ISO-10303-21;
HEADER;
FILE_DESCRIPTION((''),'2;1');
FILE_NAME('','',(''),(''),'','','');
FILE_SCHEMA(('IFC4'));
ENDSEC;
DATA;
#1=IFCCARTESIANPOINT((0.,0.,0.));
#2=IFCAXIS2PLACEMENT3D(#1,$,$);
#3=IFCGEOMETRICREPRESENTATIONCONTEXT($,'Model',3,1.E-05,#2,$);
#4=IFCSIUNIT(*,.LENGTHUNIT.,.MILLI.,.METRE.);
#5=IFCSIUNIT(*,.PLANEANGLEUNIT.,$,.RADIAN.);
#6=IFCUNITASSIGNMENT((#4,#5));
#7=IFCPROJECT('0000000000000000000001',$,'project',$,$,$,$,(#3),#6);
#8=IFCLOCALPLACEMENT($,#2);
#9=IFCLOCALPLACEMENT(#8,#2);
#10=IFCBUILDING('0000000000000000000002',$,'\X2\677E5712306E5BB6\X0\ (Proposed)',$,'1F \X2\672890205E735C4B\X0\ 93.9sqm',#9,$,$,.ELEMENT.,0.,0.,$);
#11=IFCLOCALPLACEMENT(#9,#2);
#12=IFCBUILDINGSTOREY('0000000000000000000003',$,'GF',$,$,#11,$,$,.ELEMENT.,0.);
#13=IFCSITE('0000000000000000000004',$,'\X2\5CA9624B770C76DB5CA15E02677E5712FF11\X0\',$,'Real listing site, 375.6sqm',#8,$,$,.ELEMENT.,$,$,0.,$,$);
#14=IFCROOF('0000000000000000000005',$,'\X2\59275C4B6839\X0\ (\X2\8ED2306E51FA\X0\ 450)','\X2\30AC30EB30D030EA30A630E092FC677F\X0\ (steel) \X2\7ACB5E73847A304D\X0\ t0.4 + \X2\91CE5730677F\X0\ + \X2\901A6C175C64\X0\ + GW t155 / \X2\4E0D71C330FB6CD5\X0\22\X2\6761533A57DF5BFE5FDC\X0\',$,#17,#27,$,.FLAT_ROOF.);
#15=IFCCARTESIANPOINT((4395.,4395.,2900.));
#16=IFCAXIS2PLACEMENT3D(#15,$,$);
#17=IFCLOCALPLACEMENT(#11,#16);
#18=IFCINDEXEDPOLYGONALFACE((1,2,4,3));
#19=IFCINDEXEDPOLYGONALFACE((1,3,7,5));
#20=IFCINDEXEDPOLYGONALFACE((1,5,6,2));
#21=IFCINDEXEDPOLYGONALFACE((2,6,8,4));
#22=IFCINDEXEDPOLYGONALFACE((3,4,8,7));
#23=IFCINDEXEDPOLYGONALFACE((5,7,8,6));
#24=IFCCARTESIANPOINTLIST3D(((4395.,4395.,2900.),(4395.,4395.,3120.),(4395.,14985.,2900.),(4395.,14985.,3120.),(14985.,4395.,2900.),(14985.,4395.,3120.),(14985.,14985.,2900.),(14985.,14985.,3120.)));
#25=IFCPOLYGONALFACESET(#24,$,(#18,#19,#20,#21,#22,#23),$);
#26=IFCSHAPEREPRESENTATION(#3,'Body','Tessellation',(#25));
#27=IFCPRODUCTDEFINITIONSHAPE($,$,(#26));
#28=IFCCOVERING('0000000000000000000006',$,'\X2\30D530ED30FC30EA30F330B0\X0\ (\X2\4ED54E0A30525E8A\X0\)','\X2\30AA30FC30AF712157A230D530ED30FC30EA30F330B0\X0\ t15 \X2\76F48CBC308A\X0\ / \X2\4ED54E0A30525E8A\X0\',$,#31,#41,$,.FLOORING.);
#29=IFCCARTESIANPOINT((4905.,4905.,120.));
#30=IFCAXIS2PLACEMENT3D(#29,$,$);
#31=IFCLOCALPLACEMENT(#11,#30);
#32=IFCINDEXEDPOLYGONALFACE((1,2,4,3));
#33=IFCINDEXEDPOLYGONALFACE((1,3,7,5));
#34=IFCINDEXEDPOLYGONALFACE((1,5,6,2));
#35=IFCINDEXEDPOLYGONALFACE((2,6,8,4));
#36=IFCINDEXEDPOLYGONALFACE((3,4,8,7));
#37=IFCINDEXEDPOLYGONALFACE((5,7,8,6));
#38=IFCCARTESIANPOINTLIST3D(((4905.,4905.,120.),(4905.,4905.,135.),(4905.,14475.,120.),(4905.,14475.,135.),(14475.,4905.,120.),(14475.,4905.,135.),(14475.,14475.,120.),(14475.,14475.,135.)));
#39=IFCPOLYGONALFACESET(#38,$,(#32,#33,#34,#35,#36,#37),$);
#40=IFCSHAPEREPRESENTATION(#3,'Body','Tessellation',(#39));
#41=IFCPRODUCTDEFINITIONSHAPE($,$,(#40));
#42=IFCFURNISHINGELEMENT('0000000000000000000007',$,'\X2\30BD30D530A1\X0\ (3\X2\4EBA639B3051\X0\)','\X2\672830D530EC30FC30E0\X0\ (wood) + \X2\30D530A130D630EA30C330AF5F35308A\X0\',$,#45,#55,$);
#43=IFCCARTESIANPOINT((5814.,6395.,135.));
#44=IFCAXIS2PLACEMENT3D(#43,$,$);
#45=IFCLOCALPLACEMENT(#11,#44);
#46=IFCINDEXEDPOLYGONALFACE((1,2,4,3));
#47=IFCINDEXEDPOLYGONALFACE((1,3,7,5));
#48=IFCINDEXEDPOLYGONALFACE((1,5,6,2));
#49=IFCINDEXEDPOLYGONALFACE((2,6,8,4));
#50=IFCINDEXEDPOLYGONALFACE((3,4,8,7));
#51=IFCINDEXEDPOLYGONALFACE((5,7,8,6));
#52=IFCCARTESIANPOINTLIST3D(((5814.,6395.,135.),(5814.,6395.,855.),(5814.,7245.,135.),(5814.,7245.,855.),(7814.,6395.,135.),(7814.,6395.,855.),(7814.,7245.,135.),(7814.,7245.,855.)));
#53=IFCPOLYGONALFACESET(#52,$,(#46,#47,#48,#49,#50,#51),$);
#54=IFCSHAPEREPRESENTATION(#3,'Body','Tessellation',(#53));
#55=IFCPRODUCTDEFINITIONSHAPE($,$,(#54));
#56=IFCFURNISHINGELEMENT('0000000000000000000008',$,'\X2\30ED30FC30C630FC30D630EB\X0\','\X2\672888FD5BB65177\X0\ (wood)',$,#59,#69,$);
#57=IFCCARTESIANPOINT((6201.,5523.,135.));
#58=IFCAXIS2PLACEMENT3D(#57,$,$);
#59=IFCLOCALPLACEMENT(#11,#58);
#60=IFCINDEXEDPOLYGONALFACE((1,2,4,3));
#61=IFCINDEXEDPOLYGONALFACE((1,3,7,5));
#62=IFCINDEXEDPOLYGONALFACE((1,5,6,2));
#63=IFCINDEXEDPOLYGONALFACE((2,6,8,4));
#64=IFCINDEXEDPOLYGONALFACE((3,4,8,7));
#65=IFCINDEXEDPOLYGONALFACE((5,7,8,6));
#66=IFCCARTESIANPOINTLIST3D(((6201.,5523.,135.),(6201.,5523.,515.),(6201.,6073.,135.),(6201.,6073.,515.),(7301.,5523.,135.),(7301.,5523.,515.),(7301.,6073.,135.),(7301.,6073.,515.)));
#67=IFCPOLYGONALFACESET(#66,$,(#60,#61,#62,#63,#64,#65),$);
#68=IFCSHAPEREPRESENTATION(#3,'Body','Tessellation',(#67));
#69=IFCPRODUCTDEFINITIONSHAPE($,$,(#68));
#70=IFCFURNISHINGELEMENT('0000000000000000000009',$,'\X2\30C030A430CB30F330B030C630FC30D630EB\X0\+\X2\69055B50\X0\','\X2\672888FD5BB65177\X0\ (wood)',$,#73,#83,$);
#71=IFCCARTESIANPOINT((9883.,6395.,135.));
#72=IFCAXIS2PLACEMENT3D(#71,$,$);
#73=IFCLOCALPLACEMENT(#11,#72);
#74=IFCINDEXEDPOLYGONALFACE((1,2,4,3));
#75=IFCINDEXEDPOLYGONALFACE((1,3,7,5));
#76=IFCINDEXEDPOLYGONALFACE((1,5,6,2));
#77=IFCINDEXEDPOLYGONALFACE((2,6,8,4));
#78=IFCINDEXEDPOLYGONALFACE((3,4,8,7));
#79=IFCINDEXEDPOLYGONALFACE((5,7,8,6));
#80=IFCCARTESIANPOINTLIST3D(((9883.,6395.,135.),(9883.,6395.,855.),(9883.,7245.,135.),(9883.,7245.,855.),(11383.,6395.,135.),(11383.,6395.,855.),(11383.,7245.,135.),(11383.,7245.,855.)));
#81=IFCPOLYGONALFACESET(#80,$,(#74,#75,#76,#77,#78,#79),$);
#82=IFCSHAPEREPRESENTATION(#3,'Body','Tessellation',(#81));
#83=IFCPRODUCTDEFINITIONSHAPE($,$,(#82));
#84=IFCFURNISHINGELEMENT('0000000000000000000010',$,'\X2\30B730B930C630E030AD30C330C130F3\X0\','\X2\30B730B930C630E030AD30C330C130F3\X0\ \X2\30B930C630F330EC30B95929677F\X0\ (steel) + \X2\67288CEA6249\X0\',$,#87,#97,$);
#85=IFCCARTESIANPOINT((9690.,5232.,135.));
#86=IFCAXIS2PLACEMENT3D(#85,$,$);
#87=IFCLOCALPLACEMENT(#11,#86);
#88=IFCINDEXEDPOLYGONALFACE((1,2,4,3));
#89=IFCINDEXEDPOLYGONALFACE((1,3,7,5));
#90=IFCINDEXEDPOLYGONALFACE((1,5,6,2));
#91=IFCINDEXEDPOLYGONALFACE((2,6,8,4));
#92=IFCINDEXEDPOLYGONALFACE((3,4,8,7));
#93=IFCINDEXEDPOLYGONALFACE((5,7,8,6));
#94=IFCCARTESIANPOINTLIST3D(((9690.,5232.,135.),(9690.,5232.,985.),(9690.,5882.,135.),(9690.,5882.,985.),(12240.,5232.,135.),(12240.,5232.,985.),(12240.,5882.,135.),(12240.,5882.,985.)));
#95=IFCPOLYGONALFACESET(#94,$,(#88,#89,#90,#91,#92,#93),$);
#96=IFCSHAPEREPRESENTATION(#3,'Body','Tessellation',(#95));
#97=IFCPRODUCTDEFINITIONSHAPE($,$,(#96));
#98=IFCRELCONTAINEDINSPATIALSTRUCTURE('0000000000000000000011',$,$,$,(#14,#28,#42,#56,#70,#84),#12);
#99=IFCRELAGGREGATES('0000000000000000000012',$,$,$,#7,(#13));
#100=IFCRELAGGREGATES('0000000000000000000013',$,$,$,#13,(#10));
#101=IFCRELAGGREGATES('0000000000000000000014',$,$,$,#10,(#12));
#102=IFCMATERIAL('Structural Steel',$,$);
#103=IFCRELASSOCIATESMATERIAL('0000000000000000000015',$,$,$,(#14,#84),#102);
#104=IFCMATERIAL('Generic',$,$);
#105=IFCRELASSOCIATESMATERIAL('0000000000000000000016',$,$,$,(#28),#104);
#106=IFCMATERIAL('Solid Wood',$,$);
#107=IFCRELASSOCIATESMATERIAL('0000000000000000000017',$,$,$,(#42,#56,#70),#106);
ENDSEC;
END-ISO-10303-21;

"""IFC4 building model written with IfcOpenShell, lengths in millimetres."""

from ifc_helpers import new_model, si_unit, frame, frame_2d, origin, place, context, project, spatial, rectangle, extrude, material, element, save


model = new_model("IFC4")

# Units and contexts
model_context = context("Model", 3, precision=1e-05, world=origin())
ifc_project = project(units=[si_unit("LENGTHUNIT", "METRE", prefix="MILLI"), si_unit("PLANEANGLEUNIT", "RADIAN")], contexts=[model_context])

# Site, building, storey
site_placement = place(None, origin())
site = spatial("IfcSite", under=ifc_project, at=site_placement, Name="岩手県盛岡市松園１", ObjectType="Real listing site, 375.6sqm", CompositionType="ELEMENT", RefElevation=0.0)
building_placement = place(site_placement, origin())
building = spatial("IfcBuilding", under=site, at=building_placement, Name="松園の家 (Proposed)", ObjectType="1F 木造平屋 93.9sqm", CompositionType="ELEMENT", ElevationOfRefHeight=0.0, ElevationOfTerrain=0.0)
storey_placement = place(building_placement, origin())
storey = spatial("IfcBuildingStorey", under=building, at=storey_placement, Name="GF", CompositionType="ELEMENT", Elevation=0.0)

# Shared definitions
ifc_material_1 = material(Name="Solid Wood")

# Roof
ifc_material_2 = material(Name="Structural Steel")
roof_placement = place(storey_placement, frame((4395.0, 4395.0, 2900.0)))
element("IfcRoof", 1, at=roof_placement, inside=storey, material=ifc_material_2, Name="大屋根 (軒の出 450)", Description="ガルバリウム鋼板 (steel) 立平葺き t0.4 + 野地板 + 通気層 + GW t155 / 不燃・法22条区域対応", PredefinedType="FLAT_ROOF", context=model_context, shape_type="SweptSolid", body=[
    extrude(rectangle(XDim=10590.0, YDim=10590.0, at=frame_2d((5295.0, 5295.0))), frame((4395.0, 4395.0, 2900.0)), (0.0, 0.0, 1.0), 220.0),
])

# Covering
ifc_material_3 = material(Name="Generic")
covering_placement = place(storey_placement, frame((4905.0, 4905.0, 120.0)))
element("IfcCovering", 2, at=covering_placement, inside=storey, material=ifc_material_3, Name="フローリング (仕上げ床)", Description="オーク無垢フローリング t15 直貼り / 仕上げ床", PredefinedType="FLOORING", context=model_context, shape_type="SweptSolid", body=[
    extrude(rectangle(XDim=9570.0, YDim=9570.0, at=frame_2d((4785.0, 4785.0))), frame((4905.0, 4905.0, 120.0)), (0.0, 0.0, 1.0), 15.0),
])

# Furnishing elements
furnishing_1_placement = place(storey_placement, frame((5814.0, 6395.0, 135.0)))
element("IfcFurnishingElement", 3, at=furnishing_1_placement, inside=storey, material=ifc_material_1, Name="ソファ (3人掛け)", Description="木フレーム (wood) + ファブリック張り", context=model_context, shape_type="SweptSolid", body=[
    extrude(rectangle(XDim=2000.0, YDim=850.0, at=frame_2d((1000.0, 425.0))), frame((5814.0, 6395.0, 135.0)), (0.0, 0.0, 1.0), 720.0),
])
furnishing_2_placement = place(storey_placement, frame((6201.0, 5523.0, 135.0)))
element("IfcFurnishingElement", 4, at=furnishing_2_placement, inside=storey, material=ifc_material_1, Name="ローテーブル", Description="木製家具 (wood)", context=model_context, shape_type="SweptSolid", body=[
    extrude(rectangle(XDim=1100.0, YDim=550.0, at=frame_2d((550.0, 275.0))), frame((6201.0, 5523.0, 135.0)), (0.0, 0.0, 1.0), 380.0),
])
furnishing_3_placement = place(storey_placement, frame((9883.0, 6395.0, 135.0)))
element("IfcFurnishingElement", 5, at=furnishing_3_placement, inside=storey, material=ifc_material_1, Name="ダイニングテーブル+椅子", Description="木製家具 (wood)", context=model_context, shape_type="SweptSolid", body=[
    extrude(rectangle(XDim=1500.0, YDim=850.0, at=frame_2d((750.0, 425.0))), frame((9883.0, 6395.0, 135.0)), (0.0, 0.0, 1.0), 720.0),
])
furnishing_4_placement = place(storey_placement, frame((9690.0, 5232.0, 135.0)))
element("IfcFurnishingElement", 6, at=furnishing_4_placement, inside=storey, material=ifc_material_2, Name="システムキッチン", Description="システムキッチン ステンレス天板 (steel) + 木質扉", context=model_context, shape_type="SweptSolid", body=[
    extrude(rectangle(XDim=2550.0, YDim=650.0, at=frame_2d((1275.0, 325.0))), frame((9690.0, 5232.0, 135.0)), (0.0, 0.0, 1.0), 850.0),
])

save(model, "model.ifc")
